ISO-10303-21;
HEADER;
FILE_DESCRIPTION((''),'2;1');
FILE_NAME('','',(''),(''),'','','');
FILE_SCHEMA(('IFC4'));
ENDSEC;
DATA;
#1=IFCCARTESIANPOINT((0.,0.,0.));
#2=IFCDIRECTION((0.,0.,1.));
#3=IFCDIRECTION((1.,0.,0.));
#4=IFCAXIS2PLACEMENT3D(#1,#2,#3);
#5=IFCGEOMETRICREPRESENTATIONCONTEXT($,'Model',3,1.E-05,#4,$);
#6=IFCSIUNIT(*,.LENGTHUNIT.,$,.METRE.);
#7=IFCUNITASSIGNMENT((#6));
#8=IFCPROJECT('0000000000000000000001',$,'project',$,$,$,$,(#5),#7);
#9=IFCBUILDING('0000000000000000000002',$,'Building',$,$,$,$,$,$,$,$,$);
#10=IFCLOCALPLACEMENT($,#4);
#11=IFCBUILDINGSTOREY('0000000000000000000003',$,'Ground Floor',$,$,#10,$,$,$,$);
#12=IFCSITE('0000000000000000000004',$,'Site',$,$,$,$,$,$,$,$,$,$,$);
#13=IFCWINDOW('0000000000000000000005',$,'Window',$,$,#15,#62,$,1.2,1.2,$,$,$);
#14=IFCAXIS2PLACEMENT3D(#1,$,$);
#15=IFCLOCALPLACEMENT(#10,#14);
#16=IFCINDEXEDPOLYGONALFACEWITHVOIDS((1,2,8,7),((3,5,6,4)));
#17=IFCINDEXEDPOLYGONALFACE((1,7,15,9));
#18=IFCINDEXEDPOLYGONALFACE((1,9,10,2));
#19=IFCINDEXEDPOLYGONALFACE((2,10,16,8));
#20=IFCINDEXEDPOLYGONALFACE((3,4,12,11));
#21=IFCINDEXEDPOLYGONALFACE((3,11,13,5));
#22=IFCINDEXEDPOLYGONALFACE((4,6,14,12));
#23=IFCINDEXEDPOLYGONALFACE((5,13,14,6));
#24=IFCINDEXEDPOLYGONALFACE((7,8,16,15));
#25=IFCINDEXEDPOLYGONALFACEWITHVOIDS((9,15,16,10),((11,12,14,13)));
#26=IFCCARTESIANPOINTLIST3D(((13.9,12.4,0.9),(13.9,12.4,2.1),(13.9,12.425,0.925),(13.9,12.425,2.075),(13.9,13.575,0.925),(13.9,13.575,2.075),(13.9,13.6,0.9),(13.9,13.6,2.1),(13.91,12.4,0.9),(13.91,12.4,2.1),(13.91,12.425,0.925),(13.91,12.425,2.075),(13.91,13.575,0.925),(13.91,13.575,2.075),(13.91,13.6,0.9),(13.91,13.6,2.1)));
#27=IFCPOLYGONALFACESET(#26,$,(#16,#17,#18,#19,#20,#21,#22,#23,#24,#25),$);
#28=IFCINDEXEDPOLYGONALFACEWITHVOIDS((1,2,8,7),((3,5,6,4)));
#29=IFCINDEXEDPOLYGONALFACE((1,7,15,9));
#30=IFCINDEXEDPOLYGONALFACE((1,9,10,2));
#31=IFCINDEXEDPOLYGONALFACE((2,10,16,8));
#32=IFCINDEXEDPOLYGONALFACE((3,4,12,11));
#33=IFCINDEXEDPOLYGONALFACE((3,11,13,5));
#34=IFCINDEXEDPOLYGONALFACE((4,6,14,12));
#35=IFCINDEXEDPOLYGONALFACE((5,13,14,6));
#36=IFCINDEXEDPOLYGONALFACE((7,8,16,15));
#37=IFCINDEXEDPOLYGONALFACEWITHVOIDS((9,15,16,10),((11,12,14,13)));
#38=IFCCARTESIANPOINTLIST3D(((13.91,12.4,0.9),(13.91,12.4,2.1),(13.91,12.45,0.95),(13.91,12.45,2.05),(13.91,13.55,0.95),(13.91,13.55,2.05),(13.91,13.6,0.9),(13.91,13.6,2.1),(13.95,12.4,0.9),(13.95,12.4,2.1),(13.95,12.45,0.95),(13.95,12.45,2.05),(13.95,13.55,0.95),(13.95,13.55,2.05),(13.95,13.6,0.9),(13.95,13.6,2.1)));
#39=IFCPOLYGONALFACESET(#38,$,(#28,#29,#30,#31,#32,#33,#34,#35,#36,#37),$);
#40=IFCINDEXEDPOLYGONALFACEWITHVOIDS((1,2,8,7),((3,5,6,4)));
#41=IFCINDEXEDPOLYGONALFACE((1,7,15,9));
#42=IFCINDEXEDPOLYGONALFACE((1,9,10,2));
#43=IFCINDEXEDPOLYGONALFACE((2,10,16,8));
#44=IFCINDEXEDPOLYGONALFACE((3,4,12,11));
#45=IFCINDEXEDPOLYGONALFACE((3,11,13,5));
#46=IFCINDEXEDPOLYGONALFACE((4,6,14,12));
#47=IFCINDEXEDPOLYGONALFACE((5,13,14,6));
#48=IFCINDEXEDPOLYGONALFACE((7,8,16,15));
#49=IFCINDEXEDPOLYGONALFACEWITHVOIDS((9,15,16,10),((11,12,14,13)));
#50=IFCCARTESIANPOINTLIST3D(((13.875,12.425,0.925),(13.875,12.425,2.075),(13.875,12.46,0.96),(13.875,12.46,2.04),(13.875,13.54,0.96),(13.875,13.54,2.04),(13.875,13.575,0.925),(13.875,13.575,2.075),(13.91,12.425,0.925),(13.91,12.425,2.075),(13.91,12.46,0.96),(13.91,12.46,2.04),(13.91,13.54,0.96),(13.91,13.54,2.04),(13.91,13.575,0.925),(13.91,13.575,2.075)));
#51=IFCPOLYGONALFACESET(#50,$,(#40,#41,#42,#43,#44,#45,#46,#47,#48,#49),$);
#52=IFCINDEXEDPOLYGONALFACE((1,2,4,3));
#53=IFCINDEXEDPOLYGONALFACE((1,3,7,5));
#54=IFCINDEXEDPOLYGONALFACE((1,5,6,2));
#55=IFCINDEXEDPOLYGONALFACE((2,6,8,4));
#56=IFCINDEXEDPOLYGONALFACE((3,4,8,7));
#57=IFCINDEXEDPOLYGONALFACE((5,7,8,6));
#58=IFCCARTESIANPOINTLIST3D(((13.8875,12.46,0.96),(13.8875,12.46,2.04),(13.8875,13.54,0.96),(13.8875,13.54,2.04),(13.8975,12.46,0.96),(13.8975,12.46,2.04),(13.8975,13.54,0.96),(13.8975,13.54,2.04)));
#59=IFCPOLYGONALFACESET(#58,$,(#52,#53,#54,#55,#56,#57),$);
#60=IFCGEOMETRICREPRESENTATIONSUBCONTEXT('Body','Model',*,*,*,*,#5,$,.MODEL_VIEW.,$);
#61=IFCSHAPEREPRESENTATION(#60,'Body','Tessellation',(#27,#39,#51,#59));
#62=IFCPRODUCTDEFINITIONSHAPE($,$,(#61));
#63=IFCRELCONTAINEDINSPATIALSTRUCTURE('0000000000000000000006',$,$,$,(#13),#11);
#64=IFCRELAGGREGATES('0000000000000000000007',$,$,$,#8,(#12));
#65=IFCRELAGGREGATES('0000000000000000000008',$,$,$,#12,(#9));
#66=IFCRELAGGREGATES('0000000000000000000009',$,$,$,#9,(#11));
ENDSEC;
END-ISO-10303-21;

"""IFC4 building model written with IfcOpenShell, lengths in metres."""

from ifc_helpers import new_model, si_unit, frame, origin_with_axes, place, context, subcontext, project, spatial, line, indexed_curve, outline, extrude, element, save


model = new_model("IFC4")

# Units and contexts
model_context = context("Model", 3, precision=1e-05, world=origin_with_axes())
body_context = subcontext(model_context, "Body", "Model", "MODEL_VIEW")
ifc_project = project(units=[si_unit("LENGTHUNIT", "METRE")], contexts=[model_context])

# Site, building, storey
site = spatial("IfcSite", under=ifc_project, Name="Site")
building = spatial("IfcBuilding", under=site, Name="Building")
storey_placement = place(None, origin_with_axes())
storey = spatial("IfcBuildingStorey", under=building, at=storey_placement, Name="Ground Floor")

# Window
window_placement = place(storey_placement, frame((14.0, 12.4, 0.9), z_axis=(0.0, 0.0, 1.0), x_axis=(0.0, 1.0, 0.0)))
element("IfcWindow", 1, at=window_placement, inside=storey, Name="Window", OverallHeight=1.2, OverallWidth=1.2, context=body_context, shape_type="SweptSolid", body=[
    extrude(outline(indexed_curve([(0.0, 0.0), (1.2, 0.0), (1.2, 1.2), (0.0, 1.2)], segments=[line(1, 2, 3, 4, 1)]), holes=[indexed_curve([(0.025, 0.025), (1.175, 0.025), (1.175, 1.175), (0.025, 1.175)], segments=[line(1, 2, 3, 4, 1)])]), frame((0.0, 0.09, 0.0), z_axis=(0.0, -1.0, 0.0), x_axis=(1.0, 0.0, 0.0)), (0.0, 0.0, -1.0), 0.01),
    extrude(outline(indexed_curve([(0.0, 0.0), (1.2, 0.0), (1.2, 1.2), (0.0, 1.2)], segments=[line(1, 2, 3, 4, 1)]), holes=[indexed_curve([(0.05, 0.05), (1.15, 0.05), (1.15, 1.15), (0.05, 1.15)], segments=[line(1, 2, 3, 4, 1)])]), frame((0.0, 0.05, 0.0), z_axis=(0.0, -1.0, 0.0), x_axis=(1.0, 0.0, 0.0)), (0.0, 0.0, -1.0), 0.04),
    extrude(outline(indexed_curve([(0.0, 0.0), (1.15, 0.0), (1.15, 1.15), (0.0, 1.15)], segments=[line(1, 2, 3, 4, 1)]), holes=[indexed_curve([(0.035, 0.035), (1.115, 0.035), (1.115, 1.115), (0.035, 1.115)], segments=[line(1, 2, 3, 4, 1)])]), frame((0.025, 0.09, 0.025), z_axis=(0.0, -1.0, 0.0), x_axis=(1.0, 0.0, 0.0)), (0.0, 0.0, -1.0), 0.035),
    extrude(outline(indexed_curve([(0.035, 0.035), (1.115, 0.035), (1.115, 1.115), (0.035, 1.115)], segments=[line(1, 2, 3, 4, 1)])), frame((0.025, 0.1025, 0.025), z_axis=(0.0, -1.0, 0.0), x_axis=(1.0, 0.0, 0.0)), (0.0, 0.0, -1.0), 0.01),
])

save(model, "model.ifc")
